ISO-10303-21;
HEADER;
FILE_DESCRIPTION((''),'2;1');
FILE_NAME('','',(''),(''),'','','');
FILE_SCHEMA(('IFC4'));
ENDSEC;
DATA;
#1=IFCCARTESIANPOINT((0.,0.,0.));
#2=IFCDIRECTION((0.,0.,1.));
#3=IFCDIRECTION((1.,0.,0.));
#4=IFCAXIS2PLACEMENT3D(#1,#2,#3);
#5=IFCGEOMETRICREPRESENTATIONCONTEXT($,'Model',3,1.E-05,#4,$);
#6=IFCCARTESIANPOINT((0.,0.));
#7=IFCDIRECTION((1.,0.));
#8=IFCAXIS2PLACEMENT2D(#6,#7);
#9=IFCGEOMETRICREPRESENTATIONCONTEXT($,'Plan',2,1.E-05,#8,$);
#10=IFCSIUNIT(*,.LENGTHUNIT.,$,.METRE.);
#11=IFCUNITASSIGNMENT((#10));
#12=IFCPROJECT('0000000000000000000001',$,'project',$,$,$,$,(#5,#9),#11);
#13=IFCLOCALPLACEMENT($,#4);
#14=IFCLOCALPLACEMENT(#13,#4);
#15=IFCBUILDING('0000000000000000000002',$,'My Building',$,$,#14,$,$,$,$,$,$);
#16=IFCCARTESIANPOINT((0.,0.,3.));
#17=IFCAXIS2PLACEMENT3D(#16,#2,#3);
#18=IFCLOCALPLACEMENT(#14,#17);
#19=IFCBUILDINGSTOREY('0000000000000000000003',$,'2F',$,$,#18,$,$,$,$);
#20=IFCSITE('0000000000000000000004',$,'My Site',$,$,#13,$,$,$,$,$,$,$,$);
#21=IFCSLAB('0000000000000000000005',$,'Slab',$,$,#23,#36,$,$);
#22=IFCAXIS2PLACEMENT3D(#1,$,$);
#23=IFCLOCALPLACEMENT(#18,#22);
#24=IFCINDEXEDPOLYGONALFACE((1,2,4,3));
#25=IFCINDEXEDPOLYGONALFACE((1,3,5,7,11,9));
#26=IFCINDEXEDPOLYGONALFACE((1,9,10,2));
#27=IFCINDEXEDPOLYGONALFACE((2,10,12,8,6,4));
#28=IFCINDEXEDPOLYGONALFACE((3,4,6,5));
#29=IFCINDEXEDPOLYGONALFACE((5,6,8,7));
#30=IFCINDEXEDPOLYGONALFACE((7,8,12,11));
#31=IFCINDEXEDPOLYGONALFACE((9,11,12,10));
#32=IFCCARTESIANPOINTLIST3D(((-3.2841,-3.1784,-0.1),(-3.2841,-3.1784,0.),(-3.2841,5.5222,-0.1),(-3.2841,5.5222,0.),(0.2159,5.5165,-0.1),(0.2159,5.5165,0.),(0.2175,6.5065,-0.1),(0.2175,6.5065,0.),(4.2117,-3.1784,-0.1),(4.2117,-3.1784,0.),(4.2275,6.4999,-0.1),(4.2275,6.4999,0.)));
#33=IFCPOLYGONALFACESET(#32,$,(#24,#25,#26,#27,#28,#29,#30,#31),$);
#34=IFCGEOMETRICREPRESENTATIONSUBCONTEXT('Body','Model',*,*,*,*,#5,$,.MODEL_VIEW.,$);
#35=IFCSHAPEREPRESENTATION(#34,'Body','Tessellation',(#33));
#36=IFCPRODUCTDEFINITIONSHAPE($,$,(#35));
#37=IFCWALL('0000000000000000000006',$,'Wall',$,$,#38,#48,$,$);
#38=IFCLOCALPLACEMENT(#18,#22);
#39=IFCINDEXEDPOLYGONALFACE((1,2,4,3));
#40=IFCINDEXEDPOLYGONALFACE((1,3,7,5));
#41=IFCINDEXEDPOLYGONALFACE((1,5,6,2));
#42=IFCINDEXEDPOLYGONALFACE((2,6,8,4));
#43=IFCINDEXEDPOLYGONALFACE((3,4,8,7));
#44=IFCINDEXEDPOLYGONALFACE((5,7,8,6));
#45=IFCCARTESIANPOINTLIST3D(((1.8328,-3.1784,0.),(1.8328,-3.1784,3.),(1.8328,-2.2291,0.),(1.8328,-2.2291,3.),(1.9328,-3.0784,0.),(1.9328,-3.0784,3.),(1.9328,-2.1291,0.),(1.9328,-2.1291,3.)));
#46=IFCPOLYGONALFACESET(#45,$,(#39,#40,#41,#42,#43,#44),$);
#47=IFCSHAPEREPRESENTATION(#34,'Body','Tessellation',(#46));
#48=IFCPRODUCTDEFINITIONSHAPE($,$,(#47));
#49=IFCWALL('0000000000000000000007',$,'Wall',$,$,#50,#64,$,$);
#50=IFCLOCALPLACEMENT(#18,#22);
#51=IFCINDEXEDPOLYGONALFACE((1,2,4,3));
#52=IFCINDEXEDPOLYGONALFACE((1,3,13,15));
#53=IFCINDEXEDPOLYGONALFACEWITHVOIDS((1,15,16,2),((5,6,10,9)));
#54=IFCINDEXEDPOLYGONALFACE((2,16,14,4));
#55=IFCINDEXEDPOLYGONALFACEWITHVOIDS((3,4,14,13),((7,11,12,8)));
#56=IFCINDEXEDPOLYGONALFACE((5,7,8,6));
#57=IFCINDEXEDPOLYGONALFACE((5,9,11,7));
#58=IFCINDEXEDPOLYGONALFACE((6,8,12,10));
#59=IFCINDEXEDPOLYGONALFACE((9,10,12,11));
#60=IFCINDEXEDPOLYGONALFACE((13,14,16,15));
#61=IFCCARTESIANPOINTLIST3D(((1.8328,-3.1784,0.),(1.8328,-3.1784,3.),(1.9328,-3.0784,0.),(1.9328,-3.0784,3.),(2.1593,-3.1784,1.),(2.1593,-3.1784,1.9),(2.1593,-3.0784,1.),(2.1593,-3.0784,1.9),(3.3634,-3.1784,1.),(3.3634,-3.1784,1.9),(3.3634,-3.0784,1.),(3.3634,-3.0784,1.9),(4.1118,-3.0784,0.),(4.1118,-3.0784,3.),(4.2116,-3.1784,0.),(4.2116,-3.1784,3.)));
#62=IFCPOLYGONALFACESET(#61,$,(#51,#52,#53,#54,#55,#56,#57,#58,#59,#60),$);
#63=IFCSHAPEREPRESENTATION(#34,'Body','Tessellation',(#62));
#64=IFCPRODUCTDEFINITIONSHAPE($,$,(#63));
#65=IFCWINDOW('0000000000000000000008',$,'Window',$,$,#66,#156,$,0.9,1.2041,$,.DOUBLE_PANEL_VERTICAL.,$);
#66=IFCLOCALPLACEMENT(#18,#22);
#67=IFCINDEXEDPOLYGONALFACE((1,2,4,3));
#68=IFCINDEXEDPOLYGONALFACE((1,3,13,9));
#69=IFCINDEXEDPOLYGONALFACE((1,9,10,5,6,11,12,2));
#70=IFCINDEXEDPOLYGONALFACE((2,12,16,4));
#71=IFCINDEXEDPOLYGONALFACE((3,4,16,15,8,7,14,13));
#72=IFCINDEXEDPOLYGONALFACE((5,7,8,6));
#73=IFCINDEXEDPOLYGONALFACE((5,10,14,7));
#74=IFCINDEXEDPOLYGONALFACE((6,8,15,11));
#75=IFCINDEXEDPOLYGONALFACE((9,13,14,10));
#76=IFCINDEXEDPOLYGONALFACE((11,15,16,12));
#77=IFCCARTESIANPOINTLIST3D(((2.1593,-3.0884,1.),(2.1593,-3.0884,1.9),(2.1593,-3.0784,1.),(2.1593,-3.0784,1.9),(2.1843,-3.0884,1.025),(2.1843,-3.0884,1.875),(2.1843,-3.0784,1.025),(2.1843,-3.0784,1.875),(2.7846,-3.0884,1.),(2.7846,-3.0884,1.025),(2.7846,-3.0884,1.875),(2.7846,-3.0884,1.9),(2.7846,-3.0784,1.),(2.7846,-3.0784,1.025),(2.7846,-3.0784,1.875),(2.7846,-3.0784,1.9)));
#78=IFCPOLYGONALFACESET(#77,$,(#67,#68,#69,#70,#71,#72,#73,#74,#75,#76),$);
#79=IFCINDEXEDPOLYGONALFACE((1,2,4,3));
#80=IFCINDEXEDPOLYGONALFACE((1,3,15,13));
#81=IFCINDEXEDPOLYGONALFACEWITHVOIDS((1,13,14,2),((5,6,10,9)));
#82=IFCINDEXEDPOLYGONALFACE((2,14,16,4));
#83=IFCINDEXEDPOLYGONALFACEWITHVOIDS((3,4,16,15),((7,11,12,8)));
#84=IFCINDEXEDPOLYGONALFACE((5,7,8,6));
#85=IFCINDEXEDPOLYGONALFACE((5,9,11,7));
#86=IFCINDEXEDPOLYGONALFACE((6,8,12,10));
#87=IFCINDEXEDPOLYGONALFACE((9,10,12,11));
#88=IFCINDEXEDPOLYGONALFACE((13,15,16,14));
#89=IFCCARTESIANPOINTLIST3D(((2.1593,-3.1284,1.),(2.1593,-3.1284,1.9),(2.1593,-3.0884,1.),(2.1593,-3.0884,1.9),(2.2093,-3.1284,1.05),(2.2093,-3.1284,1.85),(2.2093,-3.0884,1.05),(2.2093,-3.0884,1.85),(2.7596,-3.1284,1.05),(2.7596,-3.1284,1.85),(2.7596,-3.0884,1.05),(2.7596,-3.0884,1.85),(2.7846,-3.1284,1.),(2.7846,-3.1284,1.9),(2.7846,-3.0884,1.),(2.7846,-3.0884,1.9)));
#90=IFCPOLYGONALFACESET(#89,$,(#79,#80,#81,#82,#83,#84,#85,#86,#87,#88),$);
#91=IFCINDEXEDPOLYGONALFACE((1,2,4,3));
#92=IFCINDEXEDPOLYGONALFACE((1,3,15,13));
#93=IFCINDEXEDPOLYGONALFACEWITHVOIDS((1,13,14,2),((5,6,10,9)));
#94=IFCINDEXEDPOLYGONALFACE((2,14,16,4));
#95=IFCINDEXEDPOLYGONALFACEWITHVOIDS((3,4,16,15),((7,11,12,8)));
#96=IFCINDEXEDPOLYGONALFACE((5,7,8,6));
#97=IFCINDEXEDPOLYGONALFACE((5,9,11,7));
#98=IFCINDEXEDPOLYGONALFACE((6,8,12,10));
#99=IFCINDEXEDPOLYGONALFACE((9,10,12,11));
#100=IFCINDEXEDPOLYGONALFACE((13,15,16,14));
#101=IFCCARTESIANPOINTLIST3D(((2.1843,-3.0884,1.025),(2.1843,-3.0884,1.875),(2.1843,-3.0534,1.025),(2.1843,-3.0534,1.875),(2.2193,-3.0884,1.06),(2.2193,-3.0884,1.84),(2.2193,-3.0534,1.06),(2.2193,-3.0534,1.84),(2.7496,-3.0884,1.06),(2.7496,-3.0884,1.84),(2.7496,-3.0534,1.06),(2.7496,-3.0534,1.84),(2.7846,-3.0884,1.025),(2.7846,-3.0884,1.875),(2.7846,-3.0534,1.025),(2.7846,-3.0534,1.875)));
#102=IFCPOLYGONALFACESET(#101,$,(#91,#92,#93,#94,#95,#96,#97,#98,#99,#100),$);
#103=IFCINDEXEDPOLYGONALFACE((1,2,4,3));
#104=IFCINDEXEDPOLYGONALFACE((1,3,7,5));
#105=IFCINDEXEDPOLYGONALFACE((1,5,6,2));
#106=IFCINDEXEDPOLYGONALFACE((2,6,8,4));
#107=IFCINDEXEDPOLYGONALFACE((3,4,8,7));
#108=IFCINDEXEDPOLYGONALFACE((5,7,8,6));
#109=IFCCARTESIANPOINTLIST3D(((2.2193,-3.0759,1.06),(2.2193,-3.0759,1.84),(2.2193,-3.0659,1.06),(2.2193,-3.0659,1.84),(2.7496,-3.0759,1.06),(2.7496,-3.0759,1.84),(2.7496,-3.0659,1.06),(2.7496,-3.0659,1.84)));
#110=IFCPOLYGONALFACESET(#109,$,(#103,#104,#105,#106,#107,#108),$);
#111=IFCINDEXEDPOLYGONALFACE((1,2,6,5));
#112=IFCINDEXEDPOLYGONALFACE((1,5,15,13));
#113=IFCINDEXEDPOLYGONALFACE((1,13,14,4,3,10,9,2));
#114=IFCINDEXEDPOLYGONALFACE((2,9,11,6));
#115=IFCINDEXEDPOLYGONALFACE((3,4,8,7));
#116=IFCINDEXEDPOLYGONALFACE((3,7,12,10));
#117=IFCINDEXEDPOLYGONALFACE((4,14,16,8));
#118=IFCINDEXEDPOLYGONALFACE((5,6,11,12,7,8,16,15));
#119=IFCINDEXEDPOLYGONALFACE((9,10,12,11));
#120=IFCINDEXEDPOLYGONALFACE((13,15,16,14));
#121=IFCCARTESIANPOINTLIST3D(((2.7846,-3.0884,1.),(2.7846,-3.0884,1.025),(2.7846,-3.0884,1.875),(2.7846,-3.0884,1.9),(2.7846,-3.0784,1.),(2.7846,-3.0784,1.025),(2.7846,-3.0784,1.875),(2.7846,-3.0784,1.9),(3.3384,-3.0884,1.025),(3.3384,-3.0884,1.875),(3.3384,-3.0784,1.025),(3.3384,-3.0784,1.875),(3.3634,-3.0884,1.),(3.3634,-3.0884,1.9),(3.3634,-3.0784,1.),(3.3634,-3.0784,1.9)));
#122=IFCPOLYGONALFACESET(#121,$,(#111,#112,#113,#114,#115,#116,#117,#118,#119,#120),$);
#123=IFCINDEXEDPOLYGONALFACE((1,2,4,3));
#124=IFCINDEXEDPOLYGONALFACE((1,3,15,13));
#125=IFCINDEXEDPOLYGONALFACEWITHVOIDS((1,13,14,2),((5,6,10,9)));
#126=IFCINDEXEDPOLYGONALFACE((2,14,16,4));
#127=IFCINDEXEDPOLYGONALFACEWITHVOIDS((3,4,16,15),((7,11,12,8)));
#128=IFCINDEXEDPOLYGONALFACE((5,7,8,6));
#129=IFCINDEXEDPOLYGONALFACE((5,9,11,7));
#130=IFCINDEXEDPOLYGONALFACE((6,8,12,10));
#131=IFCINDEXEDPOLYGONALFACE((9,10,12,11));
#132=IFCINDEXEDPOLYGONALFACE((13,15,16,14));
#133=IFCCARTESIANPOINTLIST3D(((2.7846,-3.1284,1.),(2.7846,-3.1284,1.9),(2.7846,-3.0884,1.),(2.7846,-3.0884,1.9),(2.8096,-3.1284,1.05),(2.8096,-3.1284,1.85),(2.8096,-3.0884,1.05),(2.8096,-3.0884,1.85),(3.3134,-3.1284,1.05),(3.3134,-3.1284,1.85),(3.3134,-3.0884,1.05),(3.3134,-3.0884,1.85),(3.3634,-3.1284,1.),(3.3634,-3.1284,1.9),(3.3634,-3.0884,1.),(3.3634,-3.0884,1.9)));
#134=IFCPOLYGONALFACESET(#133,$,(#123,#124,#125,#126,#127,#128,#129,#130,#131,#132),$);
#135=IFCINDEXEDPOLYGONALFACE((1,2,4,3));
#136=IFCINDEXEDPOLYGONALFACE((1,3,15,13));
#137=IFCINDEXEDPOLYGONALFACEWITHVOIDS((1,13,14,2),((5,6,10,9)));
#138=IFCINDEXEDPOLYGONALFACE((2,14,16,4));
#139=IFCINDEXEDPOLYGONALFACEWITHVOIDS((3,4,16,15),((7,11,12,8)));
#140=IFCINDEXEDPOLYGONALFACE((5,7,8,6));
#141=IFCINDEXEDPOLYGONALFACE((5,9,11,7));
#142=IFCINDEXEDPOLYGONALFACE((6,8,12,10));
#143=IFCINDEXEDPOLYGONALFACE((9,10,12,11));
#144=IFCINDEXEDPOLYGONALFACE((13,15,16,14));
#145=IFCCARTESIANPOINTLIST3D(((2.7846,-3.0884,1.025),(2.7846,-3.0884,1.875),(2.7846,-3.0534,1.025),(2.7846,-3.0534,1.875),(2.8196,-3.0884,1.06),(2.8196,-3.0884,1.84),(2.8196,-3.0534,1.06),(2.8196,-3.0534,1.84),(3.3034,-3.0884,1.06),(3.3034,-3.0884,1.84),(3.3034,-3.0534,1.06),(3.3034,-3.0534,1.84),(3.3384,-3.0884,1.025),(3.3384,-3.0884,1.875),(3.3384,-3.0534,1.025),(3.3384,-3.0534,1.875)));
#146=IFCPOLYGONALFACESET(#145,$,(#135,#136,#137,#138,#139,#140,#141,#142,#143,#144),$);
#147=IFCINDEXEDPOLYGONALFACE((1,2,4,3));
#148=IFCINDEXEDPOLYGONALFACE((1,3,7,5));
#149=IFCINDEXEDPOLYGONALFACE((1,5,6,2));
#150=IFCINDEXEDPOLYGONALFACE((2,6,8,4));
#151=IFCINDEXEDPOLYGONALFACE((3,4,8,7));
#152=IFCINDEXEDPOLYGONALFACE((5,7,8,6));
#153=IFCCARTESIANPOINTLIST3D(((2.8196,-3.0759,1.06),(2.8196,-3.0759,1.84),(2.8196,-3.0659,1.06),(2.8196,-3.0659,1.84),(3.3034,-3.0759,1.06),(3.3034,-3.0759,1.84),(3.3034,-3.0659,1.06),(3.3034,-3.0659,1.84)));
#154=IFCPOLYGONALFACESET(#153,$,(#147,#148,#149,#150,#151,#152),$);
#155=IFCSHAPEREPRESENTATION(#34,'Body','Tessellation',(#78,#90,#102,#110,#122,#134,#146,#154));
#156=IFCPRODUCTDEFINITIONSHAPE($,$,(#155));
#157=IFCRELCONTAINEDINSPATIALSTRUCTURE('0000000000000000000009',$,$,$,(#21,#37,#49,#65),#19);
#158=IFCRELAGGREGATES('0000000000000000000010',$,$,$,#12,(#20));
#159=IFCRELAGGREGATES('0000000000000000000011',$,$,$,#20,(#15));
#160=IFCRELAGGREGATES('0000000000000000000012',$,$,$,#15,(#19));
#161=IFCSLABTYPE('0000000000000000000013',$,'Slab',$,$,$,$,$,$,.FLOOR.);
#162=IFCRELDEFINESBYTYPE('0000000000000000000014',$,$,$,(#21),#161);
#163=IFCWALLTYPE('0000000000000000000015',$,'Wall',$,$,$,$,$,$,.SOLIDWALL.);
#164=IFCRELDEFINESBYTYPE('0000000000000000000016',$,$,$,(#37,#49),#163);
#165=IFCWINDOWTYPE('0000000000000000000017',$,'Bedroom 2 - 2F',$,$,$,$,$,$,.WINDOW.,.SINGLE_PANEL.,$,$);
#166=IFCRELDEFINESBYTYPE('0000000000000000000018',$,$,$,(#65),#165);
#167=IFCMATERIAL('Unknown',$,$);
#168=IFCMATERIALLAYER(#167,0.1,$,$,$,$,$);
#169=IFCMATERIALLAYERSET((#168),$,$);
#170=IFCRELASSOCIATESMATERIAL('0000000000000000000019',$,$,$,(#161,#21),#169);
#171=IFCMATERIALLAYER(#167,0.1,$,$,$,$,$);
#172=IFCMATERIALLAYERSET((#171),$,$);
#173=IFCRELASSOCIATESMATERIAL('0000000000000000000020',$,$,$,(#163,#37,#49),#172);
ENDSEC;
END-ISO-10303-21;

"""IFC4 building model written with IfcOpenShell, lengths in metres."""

from ifc_helpers import new_model, entity, si_unit, frame, origin_with_axes, origin_2d_with_axis, place, context, subcontext, project, spatial, line, indexed_curve, outline, extrude, shape, source, transform, mapped, material, layer, layer_set, layer_usage, type_object, type_shapes, element, fill, save


model = new_model("IFC4")

# Units and contexts
model_context = context("Model", 3, precision=1e-05, world=origin_with_axes())
plan_context = context("Plan", 2, precision=1e-05, world=origin_2d_with_axis())
body_context_1 = subcontext(model_context, "Body", "Model", "MODEL_VIEW")
body_context_2 = subcontext(plan_context, "Body", "Plan", "PLAN_VIEW")
ifc_project = project(units=[si_unit("LENGTHUNIT", "METRE")], contexts=[model_context, plan_context])

# Site, building, storey
site_placement = place(None, origin_with_axes())
site = spatial("IfcSite", under=ifc_project, at=site_placement, Name="My Site")
building_placement = place(site_placement, origin_with_axes())
building = spatial("IfcBuilding", under=site, at=building_placement, Name="My Building")
storey_placement = place(building_placement, frame((0.0, 0.0, 3.0), z_axis=(0.0, 0.0, 1.0), x_axis=(1.0, 0.0, 0.0)))
storey = spatial("IfcBuildingStorey", under=building, at=storey_placement, Name="2F")

# Slab
ifc_material = material(Name="Unknown")
ifc_layer_1 = layer(ifc_material, 0.1)
ifc_layer_set_1 = layer_set([ifc_layer_1])
ifc_layer_usage_1 = layer_usage(ifc_layer_set_1, "AXIS3", "POSITIVE", -0.1)
slab_type = type_object("IfcSlabType", Name="Slab", PredefinedType="FLOOR", material=ifc_layer_set_1)
slab_placement = place(storey_placement, frame((4.2275, 6.4999, 0.0), z_axis=(0.0, 0.0, 1.0), x_axis=(1.0, 0.0, 0.0)))
element("IfcSlab", 1, at=slab_placement, inside=storey, type_object=slab_type, material=ifc_layer_usage_1, Name="Slab", context=body_context_1, shape_type="SweptSolid", body=[
    extrude(outline(indexed_curve([(0.0, 0.0), (-4.01, 0.0066), (-4.0116, -0.9834), (-7.5116, -0.9777), (-7.5116, -9.6783), (-0.0158, -9.6783), (0.0, 0.0)])), frame((0.0, 0.0, -0.1), z_axis=(0.0, 0.0, 1.0), x_axis=(1.0, 0.0, 0.0)), (0.0, 0.0, 1.0), 0.1),
])

# Wall
ifc_layer_2 = layer(ifc_material, 0.1)
ifc_layer_set_2 = layer_set([ifc_layer_2])
ifc_layer_usage_2 = layer_usage(ifc_layer_set_2, "AXIS2", "POSITIVE", 0.0)
wall_type = type_object("IfcWallType", Name="Wall", PredefinedType="SOLIDWALL", material=ifc_layer_set_2)
wall_1_placement = place(storey_placement, frame((1.8328, -2.2291, 0.0), z_axis=(0.0, 0.0, 1.0), x_axis=(0.0, -1.0, 0.0)))
element("IfcWall", 2, at=wall_1_placement, inside=storey, type_object=wall_type, material=ifc_layer_usage_2, Name="Wall", context=body_context_1, shape_type="SweptSolid", body=[
    extrude(outline(indexed_curve([(0.0, 0.0), (-0.1, 0.1), (0.8493, 0.1), (0.9493, 0.0)], segments=[line(1, 2, 3, 4, 1)])), origin_with_axes(), (0.0, 0.0, 1.0), 3.0),
])

# Wall, opening, window
ifc_layer_usage_3 = layer_usage(ifc_layer_set_2, "AXIS2", "POSITIVE", 0.0)
wall_2_placement = place(storey_placement, frame((1.8328, -3.1784, 0.0), z_axis=(0.0, 0.0, 1.0), x_axis=(1.0, 0.0, 0.0)))
wall_2 = element("IfcWall", 3, at=wall_2_placement, inside=storey, type_object=wall_type, material=ifc_layer_usage_3, Name="Wall", context=body_context_1, shape_type="SweptSolid", body=[
    extrude(outline(indexed_curve([(0.0, 0.0), (0.1, 0.1), (2.279, 0.1), (2.3789, 0.0)], segments=[line(1, 2, 3, 4, 1)])), origin_with_axes(), (0.0, 0.0, 1.0), 3.0),
])
shared_shape_1 = source(origin_with_axes(), body_context_1, "Body", "SweptSolid", [
    extrude(outline(indexed_curve([(0.0, 0.0), (1.2041, 0.0), (1.2041, 0.9), (0.0, 0.9)], segments=[line(1, 2, 3, 4, 1)])), frame((0.0, -0.6, 0.0), z_axis=(0.0, -1.0, 0.0), x_axis=(1.0, 0.0, 0.0)), (0.0, 0.0, -1.0), 1.2),
])
opening_1_placement = place(wall_2_placement, frame((0.3266, 0.0, 1.0), z_axis=(0.0, 0.0, 1.0), x_axis=(1.0, 0.0, 0.0)))
opening_1 = element("IfcOpeningElement", 4, at=opening_1_placement, cuts=wall_2, PredefinedType="OPENING", context=body_context_1, shape_type="MappedRepresentation", body=[
    mapped(shared_shape_1, transform((0.0, 0.0, 0.0), x_axis=(1.0, 0.0, 0.0), y_axis=(0.0, 1.0, 0.0), z_axis=(0.0, 0.0, 1.0), scale=1.0)),
])
window_type_1 = type_object("IfcWindowType", Name="Bedroom 2 - 2F", PartitioningType="SINGLE_PANEL", PredefinedType="WINDOW")
shared_shape_2 = source(origin_with_axes(), body_context_1, "Body", "SweptSolid", [
    extrude(outline(indexed_curve([(0.6253, 0.0), (0.0, 0.0), (0.0, 0.9), (0.6253, 0.9), (0.6253, 0.875), (0.025, 0.875), (0.025, 0.025), (0.6253, 0.025)], segments=[line(1, 2, 3, 4, 5, 6, 7, 8, 1)])), frame((0.0, 0.09, 0.0), z_axis=(0.0, -1.0, 0.0), x_axis=(1.0, 0.0, 0.0)), (0.0, 0.0, -1.0), 0.01),
    extrude(outline(indexed_curve([(0.0, 0.0), (0.6253, 0.0), (0.6253, 0.9), (0.0, 0.9)], segments=[line(1, 2, 3, 4, 1)]), holes=[indexed_curve([(0.05, 0.05), (0.6003, 0.05), (0.6003, 0.85), (0.05, 0.85)], segments=[line(1, 2, 3, 4, 1)])]), frame((0.0, 0.05, 0.0), z_axis=(0.0, -1.0, 0.0), x_axis=(1.0, 0.0, 0.0)), (0.0, 0.0, -1.0), 0.04),
    extrude(outline(indexed_curve([(0.0, 0.0), (0.6003, 0.0), (0.6003, 0.85), (0.0, 0.85)], segments=[line(1, 2, 3, 4, 1)]), holes=[indexed_curve([(0.035, 0.035), (0.5653, 0.035), (0.5653, 0.815), (0.035, 0.815)], segments=[line(1, 2, 3, 4, 1)])]), frame((0.025, 0.09, 0.025), z_axis=(0.0, -1.0, 0.0), x_axis=(1.0, 0.0, 0.0)), (0.0, 0.0, -1.0), 0.035),
    extrude(outline(indexed_curve([(0.035, 0.035), (0.5653, 0.035), (0.5653, 0.815), (0.035, 0.815)], segments=[line(1, 2, 3, 4, 1)])), frame((0.025, 0.1025, 0.025), z_axis=(0.0, -1.0, 0.0), x_axis=(1.0, 0.0, 0.0)), (0.0, 0.0, -1.0), 0.01),
    extrude(outline(indexed_curve([(0.0, 0.9), (0.5788, 0.9), (0.5788, 0.0), (0.0, 0.0), (0.0, 0.025), (0.5538, 0.025), (0.5538, 0.875), (0.0, 0.875)], segments=[line(1, 2, 3, 4, 5, 6, 7, 8, 1)])), frame((0.6253, 0.09, 0.0), z_axis=(0.0, -1.0, 0.0), x_axis=(1.0, 0.0, 0.0)), (0.0, 0.0, -1.0), 0.01),
    extrude(outline(indexed_curve([(0.0, 0.0), (0.5788, 0.0), (0.5788, 0.9), (0.0, 0.9)], segments=[line(1, 2, 3, 4, 1)]), holes=[indexed_curve([(0.025, 0.05), (0.5288, 0.05), (0.5288, 0.85), (0.025, 0.85)], segments=[line(1, 2, 3, 4, 1)])]), frame((0.6253, 0.05, 0.0), z_axis=(0.0, -1.0, 0.0), x_axis=(1.0, 0.0, 0.0)), (0.0, 0.0, -1.0), 0.04),
    extrude(outline(indexed_curve([(0.0, 0.0), (0.5538, 0.0), (0.5538, 0.85), (0.0, 0.85)], segments=[line(1, 2, 3, 4, 1)]), holes=[indexed_curve([(0.035, 0.035), (0.5188, 0.035), (0.5188, 0.815), (0.035, 0.815)], segments=[line(1, 2, 3, 4, 1)])]), frame((0.6253, 0.09, 0.025), z_axis=(0.0, -1.0, 0.0), x_axis=(1.0, 0.0, 0.0)), (0.0, 0.0, -1.0), 0.035),
    extrude(outline(indexed_curve([(0.035, 0.035), (0.5188, 0.035), (0.5188, 0.815), (0.035, 0.815)], segments=[line(1, 2, 3, 4, 1)])), frame((0.6253, 0.1025, 0.025), z_axis=(0.0, -1.0, 0.0), x_axis=(1.0, 0.0, 0.0)), (0.0, 0.0, -1.0), 0.01),
])
shared_shape_3 = source(origin_with_axes(), body_context_2, "Body", "Curve2D", [
    entity("IfcIndexedPolyCurve", entity("IfcCartesianPointList2D", [[0.05, 0.05], [0.6003, 0.05]])),
    entity("IfcIndexedPolyCurve", entity("IfcCartesianPointList2D", [[0.0, 0.1], [0.025, 0.1], [0.025, 0.09], [0.05, 0.09], [0.05, 0.05], [0.0, 0.05]]), [entity("IfcLineIndex", [1, 2, 3, 4, 5, 6, 1])]),
    entity("IfcIndexedPolyCurve", entity("IfcCartesianPointList2D", [[0.6253, 0.1], [0.6253, 0.1], [0.6253, 0.09], [0.6003, 0.09], [0.6003, 0.05], [0.6253, 0.05]])),
    entity("IfcIndexedPolyCurve", entity("IfcCartesianPointList2D", [[0.025, 0.09], [0.06, 0.09], [0.06, 0.125], [0.025, 0.125]]), [entity("IfcLineIndex", [1, 2, 3, 4, 1])]),
    entity("IfcIndexedPolyCurve", entity("IfcCartesianPointList2D", [[0.6253, 0.09], [0.5903, 0.09], [0.5903, 0.125], [0.6253, 0.125]]), [entity("IfcLineIndex", [1, 2, 3, 4, 1])]),
    entity("IfcIndexedPolyCurve", entity("IfcCartesianPointList2D", [[0.06, 0.09], [0.5903, 0.09]])),
    entity("IfcIndexedPolyCurve", entity("IfcCartesianPointList2D", [[0.06, 0.125], [0.5903, 0.125]])),
    entity("IfcIndexedPolyCurve", entity("IfcCartesianPointList2D", [[0.06, 0.1075], [0.5903, 0.1075]])),
    entity("IfcIndexedPolyCurve", entity("IfcCartesianPointList2D", [[0.6503, 0.05], [1.1541, 0.05]])),
    entity("IfcIndexedPolyCurve", entity("IfcCartesianPointList2D", [[0.6253, 0.1], [0.6253, 0.1], [0.6253, 0.09], [0.6503, 0.09], [0.6503, 0.05], [0.6253, 0.05]])),
    entity("IfcIndexedPolyCurve", entity("IfcCartesianPointList2D", [[1.2041, 0.1], [1.1791, 0.1], [1.1791, 0.09], [1.1541, 0.09], [1.1541, 0.05], [1.2041, 0.05]]), [entity("IfcLineIndex", [1, 2, 3, 4, 5, 6, 1])]),
    entity("IfcIndexedPolyCurve", entity("IfcCartesianPointList2D", [[0.6253, 0.09], [0.6603, 0.09], [0.6603, 0.125], [0.6253, 0.125]]), [entity("IfcLineIndex", [1, 2, 3, 4, 1])]),
    entity("IfcIndexedPolyCurve", entity("IfcCartesianPointList2D", [[1.1791, 0.09], [1.1441, 0.09], [1.1441, 0.125], [1.1791, 0.125]]), [entity("IfcLineIndex", [1, 2, 3, 4, 1])]),
    entity("IfcIndexedPolyCurve", entity("IfcCartesianPointList2D", [[0.6603, 0.09], [1.1441, 0.09]])),
    entity("IfcIndexedPolyCurve", entity("IfcCartesianPointList2D", [[0.6603, 0.125], [1.1441, 0.125]])),
    entity("IfcIndexedPolyCurve", entity("IfcCartesianPointList2D", [[0.6603, 0.1075], [1.1441, 0.1075]])),
])
type_shapes(window_type_1, [shared_shape_2, shared_shape_3])
window_1_placement = place(opening_1_placement, origin_with_axes())
window_1 = element("IfcWindow", 5, at=window_1_placement, inside=storey, type_object=window_type_1, Name="Window", OverallHeight=0.9, OverallWidth=1.2041, PartitioningType="DOUBLE_PANEL_VERTICAL", shapes=[
    shape(body_context_1, "Body", "MappedRepresentation", [mapped(shared_shape_2, transform((0.0, 0.0, 0.0), x_axis=(1.0, 0.0, 0.0), y_axis=(0.0, 1.0, 0.0), z_axis=(0.0, 0.0, 1.0), scale=1.0))]),
    shape(body_context_2, "Body", "MappedRepresentation", [mapped(shared_shape_3, transform((0.0, 0.0, 0.0), x_axis=(1.0, 0.0, 0.0), y_axis=(0.0, 1.0, 0.0), z_axis=(0.0, 0.0, 1.0), scale=1.0))]),
])
fill(opening_1, window_1)

save(model, "model.ifc")
